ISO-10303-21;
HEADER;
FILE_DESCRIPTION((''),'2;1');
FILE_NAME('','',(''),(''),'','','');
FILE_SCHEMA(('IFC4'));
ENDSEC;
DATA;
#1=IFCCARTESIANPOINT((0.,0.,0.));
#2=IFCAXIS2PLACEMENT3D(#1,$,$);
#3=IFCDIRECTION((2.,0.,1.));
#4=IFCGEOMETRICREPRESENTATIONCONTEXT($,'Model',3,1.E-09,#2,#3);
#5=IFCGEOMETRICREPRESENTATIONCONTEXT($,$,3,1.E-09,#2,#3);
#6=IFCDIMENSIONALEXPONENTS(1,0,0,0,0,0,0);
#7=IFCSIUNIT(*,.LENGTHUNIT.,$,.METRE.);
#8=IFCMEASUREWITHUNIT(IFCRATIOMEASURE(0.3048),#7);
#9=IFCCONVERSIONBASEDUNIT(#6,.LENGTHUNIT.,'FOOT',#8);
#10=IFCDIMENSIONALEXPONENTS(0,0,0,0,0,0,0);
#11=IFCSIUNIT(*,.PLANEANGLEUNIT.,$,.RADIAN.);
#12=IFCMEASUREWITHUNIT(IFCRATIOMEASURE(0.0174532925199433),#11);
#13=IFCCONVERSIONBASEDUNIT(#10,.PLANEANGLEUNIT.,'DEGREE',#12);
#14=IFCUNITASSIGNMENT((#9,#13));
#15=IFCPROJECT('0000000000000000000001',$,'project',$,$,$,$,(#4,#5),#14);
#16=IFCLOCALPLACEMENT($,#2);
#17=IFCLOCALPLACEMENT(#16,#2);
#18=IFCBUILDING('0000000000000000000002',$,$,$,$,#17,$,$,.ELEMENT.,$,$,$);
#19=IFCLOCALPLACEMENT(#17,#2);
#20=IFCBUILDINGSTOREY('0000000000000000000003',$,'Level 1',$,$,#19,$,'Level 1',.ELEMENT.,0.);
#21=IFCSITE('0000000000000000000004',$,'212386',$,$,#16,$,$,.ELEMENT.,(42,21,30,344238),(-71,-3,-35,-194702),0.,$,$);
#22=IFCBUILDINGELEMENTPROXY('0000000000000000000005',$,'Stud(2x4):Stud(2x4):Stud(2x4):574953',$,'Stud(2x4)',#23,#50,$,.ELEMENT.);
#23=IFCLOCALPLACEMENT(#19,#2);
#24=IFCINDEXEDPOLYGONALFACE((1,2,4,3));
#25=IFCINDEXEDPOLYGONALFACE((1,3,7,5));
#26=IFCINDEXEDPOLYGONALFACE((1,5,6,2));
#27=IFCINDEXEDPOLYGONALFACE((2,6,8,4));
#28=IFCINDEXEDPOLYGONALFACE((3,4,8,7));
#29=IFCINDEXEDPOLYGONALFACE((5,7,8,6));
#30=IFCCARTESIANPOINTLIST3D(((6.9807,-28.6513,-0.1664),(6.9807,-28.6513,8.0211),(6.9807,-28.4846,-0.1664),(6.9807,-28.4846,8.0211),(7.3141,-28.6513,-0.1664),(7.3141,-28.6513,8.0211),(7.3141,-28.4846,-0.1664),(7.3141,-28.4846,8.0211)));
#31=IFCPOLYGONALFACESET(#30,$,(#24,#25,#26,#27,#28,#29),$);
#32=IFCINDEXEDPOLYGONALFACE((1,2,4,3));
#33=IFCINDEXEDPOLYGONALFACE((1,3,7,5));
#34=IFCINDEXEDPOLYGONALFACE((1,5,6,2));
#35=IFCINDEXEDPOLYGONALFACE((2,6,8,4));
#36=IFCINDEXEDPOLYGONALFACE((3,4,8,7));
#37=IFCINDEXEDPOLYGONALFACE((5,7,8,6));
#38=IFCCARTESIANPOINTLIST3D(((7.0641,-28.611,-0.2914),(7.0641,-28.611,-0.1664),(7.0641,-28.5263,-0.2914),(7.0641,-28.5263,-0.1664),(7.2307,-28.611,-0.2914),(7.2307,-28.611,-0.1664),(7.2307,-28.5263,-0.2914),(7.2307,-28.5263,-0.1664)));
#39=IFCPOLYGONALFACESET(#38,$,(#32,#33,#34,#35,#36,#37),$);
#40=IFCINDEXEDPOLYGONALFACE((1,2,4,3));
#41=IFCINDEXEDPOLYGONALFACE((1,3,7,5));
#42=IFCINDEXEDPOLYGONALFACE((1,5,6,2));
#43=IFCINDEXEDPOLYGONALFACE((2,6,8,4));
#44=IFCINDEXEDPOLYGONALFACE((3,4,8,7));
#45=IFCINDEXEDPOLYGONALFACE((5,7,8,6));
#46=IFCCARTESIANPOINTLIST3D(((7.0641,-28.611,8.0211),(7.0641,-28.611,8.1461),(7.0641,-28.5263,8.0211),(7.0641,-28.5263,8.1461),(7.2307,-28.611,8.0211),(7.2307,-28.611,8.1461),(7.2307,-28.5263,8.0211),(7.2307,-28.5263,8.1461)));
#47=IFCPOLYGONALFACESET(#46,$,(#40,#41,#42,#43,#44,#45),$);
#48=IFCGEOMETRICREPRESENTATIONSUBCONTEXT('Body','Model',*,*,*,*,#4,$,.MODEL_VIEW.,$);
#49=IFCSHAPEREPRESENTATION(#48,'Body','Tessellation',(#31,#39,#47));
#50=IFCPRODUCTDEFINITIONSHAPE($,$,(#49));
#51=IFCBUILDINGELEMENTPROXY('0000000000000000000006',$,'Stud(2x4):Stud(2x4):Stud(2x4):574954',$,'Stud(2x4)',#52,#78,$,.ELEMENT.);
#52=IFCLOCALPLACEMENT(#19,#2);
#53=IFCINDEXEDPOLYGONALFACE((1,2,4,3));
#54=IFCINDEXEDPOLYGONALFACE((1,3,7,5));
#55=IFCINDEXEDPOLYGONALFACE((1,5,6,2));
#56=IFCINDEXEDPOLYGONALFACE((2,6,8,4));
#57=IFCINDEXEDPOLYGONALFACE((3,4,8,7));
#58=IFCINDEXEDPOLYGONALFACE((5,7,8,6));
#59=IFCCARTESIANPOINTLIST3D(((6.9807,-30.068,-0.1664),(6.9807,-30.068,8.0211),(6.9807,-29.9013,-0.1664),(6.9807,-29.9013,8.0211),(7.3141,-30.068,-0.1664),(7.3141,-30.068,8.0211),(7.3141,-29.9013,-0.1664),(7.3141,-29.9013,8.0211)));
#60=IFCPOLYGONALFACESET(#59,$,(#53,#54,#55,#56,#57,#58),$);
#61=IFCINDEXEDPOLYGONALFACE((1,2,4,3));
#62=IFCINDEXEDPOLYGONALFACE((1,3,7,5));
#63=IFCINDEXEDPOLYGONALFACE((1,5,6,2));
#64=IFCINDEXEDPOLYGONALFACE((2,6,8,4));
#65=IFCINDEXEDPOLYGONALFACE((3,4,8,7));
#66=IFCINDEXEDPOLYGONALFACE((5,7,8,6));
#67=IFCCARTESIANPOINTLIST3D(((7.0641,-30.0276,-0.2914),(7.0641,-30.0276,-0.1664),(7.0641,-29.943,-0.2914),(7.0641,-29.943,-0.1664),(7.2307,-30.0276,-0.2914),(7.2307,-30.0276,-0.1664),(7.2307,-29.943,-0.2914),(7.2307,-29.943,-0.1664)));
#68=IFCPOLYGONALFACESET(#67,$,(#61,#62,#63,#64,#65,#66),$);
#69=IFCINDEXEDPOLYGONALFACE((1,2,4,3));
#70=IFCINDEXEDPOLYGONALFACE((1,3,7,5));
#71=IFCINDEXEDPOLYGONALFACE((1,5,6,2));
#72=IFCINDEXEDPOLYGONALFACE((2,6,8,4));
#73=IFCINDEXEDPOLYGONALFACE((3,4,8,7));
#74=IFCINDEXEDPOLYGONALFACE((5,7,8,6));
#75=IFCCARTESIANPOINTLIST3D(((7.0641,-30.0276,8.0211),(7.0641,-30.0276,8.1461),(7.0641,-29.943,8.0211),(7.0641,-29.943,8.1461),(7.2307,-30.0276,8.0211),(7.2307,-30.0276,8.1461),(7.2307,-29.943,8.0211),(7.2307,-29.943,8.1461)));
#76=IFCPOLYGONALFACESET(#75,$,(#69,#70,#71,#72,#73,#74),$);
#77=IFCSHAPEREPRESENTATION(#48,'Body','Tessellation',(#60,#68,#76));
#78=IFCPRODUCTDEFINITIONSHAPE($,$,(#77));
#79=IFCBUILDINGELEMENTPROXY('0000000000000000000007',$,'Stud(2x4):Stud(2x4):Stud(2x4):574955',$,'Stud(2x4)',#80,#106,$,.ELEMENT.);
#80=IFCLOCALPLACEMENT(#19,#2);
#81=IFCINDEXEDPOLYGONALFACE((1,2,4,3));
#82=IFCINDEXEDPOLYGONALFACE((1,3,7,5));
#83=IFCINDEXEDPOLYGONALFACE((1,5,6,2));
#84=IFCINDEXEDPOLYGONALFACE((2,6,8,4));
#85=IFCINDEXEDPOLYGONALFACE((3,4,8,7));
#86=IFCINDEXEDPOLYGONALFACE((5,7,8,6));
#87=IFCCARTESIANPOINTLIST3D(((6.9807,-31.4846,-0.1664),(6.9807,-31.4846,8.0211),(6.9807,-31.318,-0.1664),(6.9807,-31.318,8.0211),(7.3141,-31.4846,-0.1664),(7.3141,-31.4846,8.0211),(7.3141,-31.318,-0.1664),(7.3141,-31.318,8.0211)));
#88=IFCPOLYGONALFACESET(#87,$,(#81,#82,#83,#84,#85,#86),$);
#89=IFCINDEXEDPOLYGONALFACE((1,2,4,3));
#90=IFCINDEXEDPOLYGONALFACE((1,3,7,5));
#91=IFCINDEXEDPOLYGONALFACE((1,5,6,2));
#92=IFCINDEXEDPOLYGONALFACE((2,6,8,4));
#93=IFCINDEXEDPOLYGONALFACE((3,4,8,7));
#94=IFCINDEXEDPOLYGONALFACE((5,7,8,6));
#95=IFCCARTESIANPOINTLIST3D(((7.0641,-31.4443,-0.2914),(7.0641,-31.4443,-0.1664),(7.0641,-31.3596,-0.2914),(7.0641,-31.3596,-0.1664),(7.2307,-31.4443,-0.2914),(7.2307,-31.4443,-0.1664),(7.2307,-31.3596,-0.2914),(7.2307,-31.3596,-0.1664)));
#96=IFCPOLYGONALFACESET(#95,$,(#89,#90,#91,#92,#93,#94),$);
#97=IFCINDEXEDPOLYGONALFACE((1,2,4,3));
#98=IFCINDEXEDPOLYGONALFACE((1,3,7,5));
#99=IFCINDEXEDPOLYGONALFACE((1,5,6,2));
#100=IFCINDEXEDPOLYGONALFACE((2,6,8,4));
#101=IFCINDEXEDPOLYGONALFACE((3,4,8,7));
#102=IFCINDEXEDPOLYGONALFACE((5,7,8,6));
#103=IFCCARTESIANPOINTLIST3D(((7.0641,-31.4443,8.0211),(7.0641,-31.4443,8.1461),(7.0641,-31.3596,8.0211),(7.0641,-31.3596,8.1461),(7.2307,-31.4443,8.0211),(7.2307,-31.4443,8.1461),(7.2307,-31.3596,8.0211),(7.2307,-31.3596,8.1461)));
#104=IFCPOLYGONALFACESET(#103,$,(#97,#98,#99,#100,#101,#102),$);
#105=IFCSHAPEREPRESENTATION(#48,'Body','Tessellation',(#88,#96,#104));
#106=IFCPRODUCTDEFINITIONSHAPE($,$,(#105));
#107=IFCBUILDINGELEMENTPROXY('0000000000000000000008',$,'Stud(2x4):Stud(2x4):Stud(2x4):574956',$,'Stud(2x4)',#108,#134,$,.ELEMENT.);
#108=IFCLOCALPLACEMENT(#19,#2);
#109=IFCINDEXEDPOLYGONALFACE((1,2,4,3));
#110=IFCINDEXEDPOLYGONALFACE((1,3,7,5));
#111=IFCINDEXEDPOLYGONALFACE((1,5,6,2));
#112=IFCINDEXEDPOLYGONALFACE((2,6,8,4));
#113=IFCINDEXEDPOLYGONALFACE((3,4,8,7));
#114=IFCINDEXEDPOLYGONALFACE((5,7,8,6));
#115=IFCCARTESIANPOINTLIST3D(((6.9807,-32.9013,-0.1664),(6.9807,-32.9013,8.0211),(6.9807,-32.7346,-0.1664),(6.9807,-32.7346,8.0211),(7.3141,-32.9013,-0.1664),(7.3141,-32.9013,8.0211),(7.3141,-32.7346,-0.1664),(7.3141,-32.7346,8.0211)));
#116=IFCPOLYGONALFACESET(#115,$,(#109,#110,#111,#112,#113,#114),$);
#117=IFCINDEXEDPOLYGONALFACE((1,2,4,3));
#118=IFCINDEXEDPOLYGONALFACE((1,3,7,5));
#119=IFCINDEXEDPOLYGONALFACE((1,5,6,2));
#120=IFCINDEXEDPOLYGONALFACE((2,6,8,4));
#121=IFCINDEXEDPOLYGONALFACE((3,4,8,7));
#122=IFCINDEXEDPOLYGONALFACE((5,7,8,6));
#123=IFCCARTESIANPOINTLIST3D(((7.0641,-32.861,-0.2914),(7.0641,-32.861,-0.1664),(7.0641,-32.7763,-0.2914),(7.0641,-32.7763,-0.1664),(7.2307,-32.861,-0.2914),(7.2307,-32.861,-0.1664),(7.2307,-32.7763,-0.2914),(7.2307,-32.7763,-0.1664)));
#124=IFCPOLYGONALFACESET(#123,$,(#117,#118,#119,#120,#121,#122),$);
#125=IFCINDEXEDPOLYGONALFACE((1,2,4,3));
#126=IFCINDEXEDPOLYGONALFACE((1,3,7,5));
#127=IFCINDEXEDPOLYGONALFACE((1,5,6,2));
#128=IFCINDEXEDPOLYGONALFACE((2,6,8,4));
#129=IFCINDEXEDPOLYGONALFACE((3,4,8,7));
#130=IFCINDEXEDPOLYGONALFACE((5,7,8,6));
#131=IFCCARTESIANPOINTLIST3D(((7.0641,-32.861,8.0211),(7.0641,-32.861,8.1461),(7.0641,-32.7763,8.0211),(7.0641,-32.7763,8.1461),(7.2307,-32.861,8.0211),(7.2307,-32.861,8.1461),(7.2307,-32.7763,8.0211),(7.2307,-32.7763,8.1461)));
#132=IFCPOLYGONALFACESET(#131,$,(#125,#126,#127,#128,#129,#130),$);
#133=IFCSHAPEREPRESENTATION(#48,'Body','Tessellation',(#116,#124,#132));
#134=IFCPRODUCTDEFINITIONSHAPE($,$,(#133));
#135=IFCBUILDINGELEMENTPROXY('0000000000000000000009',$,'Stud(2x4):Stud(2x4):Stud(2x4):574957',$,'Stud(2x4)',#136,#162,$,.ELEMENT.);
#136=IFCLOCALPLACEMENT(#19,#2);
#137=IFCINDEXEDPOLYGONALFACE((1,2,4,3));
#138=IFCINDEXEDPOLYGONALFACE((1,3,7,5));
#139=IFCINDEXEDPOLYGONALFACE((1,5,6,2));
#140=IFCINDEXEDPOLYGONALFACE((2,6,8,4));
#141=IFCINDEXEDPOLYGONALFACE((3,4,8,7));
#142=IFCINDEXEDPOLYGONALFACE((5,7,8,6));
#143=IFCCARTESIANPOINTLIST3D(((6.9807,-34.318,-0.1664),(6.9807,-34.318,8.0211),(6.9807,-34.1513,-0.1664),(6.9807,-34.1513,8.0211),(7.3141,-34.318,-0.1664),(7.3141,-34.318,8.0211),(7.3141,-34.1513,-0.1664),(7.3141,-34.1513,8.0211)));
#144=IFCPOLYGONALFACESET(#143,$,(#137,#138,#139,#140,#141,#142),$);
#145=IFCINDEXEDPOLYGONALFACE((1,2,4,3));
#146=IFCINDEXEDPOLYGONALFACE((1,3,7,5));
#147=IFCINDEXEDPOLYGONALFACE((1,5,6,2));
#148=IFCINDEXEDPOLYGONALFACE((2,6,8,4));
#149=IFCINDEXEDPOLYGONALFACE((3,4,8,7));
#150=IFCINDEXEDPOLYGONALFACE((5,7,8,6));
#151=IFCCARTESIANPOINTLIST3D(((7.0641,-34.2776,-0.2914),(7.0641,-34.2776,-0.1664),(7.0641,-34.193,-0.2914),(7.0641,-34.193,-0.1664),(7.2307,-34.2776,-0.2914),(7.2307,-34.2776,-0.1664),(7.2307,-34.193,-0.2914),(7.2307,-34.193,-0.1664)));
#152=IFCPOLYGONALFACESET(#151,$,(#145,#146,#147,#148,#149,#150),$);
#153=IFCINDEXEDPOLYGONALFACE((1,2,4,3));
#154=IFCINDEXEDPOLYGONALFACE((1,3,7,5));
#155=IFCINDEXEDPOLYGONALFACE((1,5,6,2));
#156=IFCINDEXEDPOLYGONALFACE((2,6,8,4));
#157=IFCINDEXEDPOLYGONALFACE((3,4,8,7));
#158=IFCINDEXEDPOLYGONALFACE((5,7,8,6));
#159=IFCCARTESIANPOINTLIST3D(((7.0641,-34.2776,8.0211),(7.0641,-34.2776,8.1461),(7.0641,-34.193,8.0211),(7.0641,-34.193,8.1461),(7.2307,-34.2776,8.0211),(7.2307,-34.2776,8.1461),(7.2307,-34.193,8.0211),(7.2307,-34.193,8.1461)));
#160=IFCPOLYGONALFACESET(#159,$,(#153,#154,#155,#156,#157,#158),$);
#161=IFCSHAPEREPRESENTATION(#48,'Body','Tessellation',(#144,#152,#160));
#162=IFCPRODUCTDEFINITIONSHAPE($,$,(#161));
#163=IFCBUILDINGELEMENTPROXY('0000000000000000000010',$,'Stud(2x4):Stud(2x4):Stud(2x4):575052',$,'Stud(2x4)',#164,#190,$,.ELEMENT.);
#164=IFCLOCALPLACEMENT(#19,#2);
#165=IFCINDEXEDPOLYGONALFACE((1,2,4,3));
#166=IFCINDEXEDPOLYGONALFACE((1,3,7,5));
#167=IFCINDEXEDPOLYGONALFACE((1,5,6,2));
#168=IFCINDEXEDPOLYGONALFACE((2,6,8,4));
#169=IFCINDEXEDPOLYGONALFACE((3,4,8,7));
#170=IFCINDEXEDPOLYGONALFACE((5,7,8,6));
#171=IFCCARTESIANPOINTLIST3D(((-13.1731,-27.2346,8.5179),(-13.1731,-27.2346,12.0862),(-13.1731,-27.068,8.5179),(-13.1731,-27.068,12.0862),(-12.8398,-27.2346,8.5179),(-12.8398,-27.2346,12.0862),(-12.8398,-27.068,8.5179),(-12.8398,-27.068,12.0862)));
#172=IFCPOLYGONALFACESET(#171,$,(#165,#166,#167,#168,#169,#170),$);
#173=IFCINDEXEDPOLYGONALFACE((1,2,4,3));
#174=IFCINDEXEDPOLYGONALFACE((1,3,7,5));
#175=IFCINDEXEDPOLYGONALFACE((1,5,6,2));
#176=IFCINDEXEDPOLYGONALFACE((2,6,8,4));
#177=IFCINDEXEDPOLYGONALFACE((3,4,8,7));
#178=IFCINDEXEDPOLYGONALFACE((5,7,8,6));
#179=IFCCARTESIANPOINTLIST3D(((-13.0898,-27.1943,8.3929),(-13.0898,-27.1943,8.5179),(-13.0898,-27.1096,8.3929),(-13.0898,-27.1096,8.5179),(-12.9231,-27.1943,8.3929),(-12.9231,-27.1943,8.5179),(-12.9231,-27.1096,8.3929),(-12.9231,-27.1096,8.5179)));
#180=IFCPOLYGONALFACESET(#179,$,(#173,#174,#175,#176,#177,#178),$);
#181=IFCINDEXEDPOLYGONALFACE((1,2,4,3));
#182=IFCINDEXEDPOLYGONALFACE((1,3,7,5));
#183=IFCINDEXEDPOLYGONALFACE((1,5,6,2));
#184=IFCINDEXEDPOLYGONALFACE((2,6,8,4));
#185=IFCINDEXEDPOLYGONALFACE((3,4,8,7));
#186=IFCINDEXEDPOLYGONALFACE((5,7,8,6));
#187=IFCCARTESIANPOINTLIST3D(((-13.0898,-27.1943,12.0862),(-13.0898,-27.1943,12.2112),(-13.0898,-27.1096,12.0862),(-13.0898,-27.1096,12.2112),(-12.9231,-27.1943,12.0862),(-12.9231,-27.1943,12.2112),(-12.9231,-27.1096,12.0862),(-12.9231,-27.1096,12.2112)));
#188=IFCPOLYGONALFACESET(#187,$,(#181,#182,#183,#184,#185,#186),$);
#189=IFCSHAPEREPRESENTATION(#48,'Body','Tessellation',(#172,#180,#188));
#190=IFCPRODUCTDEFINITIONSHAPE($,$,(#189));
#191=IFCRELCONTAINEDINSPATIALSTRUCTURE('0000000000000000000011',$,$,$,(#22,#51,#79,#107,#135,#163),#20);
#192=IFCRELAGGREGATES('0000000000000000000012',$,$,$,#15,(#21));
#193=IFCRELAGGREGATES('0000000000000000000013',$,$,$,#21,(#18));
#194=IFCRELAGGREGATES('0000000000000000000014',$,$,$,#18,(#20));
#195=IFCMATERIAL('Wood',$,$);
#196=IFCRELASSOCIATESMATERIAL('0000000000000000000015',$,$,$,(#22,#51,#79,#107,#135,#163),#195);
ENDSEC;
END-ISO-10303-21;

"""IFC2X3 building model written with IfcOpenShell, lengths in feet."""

from ifc_helpers import new_model, entity, si_unit, converted_unit, direction, frame, frame_2d, origin, place, context, subcontext, project, spatial, rectangle, extrude, source, transform, mapped, material, element, save


model = new_model("IFC2X3")

# Units and contexts
model_context = context("Model", 3, precision=1e-09, world=origin(), true_north=direction((2.0, 0.0, 1.0)))
context_of_model = context(None, 3, precision=1e-09, world=origin(), true_north=direction((2.0, 0.0, 1.0)))
body_context = subcontext(model_context, "Body", "Model", "MODEL_VIEW")
ifc_project = project(units=[converted_unit("LENGTHUNIT", "FOOT", entity("IfcRatioMeasure", 0.3048), si_unit("LENGTHUNIT", "METRE"), dimensions=[1, 0, 0, 0, 0, 0, 0]), converted_unit("PLANEANGLEUNIT", "DEGREE", entity("IfcRatioMeasure", 0.0174532925199433), si_unit("PLANEANGLEUNIT", "RADIAN"), dimensions=[0, 0, 0, 0, 0, 0, 0])], contexts=[model_context, context_of_model])

# Site, building, storey
site_placement = place(None, origin())
site = spatial("IfcSite", under=ifc_project, at=site_placement, Name="212386", CompositionType="ELEMENT", RefLatitude=(42, 21, 30, 344238), RefLongitude=(-71, -3, -35, -194702), RefElevation=0.0)
building_placement = place(site_placement, origin())
building = spatial("IfcBuilding", under=site, at=building_placement, CompositionType="ELEMENT")
storey_placement = place(building_placement, origin())
storey = spatial("IfcBuildingStorey", under=building, at=storey_placement, Name="Level 1", LongName="Level 1", CompositionType="ELEMENT", Elevation=0.0)

# Building element proxies
ifc_material = material(Name="Wood")
shared_shape_1 = source(origin(), body_context, "Body", "SweptSolid", [
    extrude(rectangle(XDim=0.3333, YDim=0.1667, at=frame_2d((0.0, 0.0), x_axis=(1.0, 0.0))), frame((7.1474, -28.568, -0.1664), z_axis=(0.0, 0.0, 1.0), x_axis=(-1.0, 0.0, 0.0)), (0.0, 0.0, 1.0), 8.1875),
    extrude(rectangle(XDim=0.1667, YDim=0.0847, at=frame_2d((0.0, 0.0), x_axis=(1.0, 0.0))), frame((7.1474, -28.5686, -0.2914), z_axis=(0.0, 0.0, 1.0), x_axis=(-1.0, 0.0, 0.0)), (0.0, 0.0, 1.0), 0.125),
    extrude(rectangle(XDim=0.0847, YDim=0.1667, at=frame_2d((0.0, 0.0), x_axis=(1.0, 0.0))), frame((7.1474, -28.5686, 8.0211), z_axis=(0.0, 0.0, 1.0), x_axis=(0.0, -1.0, 0.0)), (0.0, 0.0, 1.0), 0.125),
])
proxy_1_placement = place(storey_placement, origin())
element("IfcBuildingElementProxy", 1, at=proxy_1_placement, inside=storey, material=ifc_material, Name="Stud(2x4):Stud(2x4):Stud(2x4):574953", ObjectType="Stud(2x4)", CompositionType="ELEMENT", context=body_context, shape_type="MappedRepresentation", body=[
    mapped(shared_shape_1, transform((0.0, 0.0, 0.0), scale=1.0)),
])
shared_shape_2 = source(origin(), body_context, "Body", "SweptSolid", [
    extrude(rectangle(XDim=0.3333, YDim=0.1667, at=frame_2d((0.0, 0.0), x_axis=(1.0, 0.0))), frame((7.1474, -29.9846, -0.1664), z_axis=(0.0, 0.0, 1.0), x_axis=(-1.0, 0.0, 0.0)), (0.0, 0.0, 1.0), 8.1875),
    extrude(rectangle(XDim=0.1667, YDim=0.0847, at=frame_2d((0.0, 0.0), x_axis=(1.0, 0.0))), frame((7.1474, -29.9853, -0.2914), z_axis=(0.0, 0.0, 1.0), x_axis=(-1.0, 0.0, 0.0)), (0.0, 0.0, 1.0), 0.125),
    extrude(rectangle(XDim=0.0847, YDim=0.1667, at=frame_2d((0.0, 0.0), x_axis=(1.0, 0.0))), frame((7.1474, -29.9853, 8.0211), z_axis=(0.0, 0.0, 1.0), x_axis=(0.0, -1.0, 0.0)), (0.0, 0.0, 1.0), 0.125),
])
proxy_2_placement = place(storey_placement, origin())
element("IfcBuildingElementProxy", 2, at=proxy_2_placement, inside=storey, material=ifc_material, Name="Stud(2x4):Stud(2x4):Stud(2x4):574954", ObjectType="Stud(2x4)", CompositionType="ELEMENT", context=body_context, shape_type="MappedRepresentation", body=[
    mapped(shared_shape_2, transform((0.0, 0.0, 0.0), scale=1.0)),
])
shared_shape_3 = source(origin(), body_context, "Body", "SweptSolid", [
    extrude(rectangle(XDim=0.3333, YDim=0.1667, at=frame_2d((0.0, 0.0), x_axis=(1.0, 0.0))), frame((7.1474, -31.4013, -0.1664), z_axis=(0.0, 0.0, 1.0), x_axis=(-1.0, 0.0, 0.0)), (0.0, 0.0, 1.0), 8.1875),
    extrude(rectangle(XDim=0.1667, YDim=0.0847, at=frame_2d((0.0, 0.0), x_axis=(1.0, 0.0))), frame((7.1474, -31.402, -0.2914), z_axis=(0.0, 0.0, 1.0), x_axis=(-1.0, 0.0, 0.0)), (0.0, 0.0, 1.0), 0.125),
    extrude(rectangle(XDim=0.0847, YDim=0.1667, at=frame_2d((0.0, 0.0), x_axis=(1.0, 0.0))), frame((7.1474, -31.402, 8.0211), z_axis=(0.0, 0.0, 1.0), x_axis=(0.0, -1.0, 0.0)), (0.0, 0.0, 1.0), 0.125),
])
proxy_3_placement = place(storey_placement, origin())
element("IfcBuildingElementProxy", 3, at=proxy_3_placement, inside=storey, material=ifc_material, Name="Stud(2x4):Stud(2x4):Stud(2x4):574955", ObjectType="Stud(2x4)", CompositionType="ELEMENT", context=body_context, shape_type="MappedRepresentation", body=[
    mapped(shared_shape_3, transform((0.0, 0.0, 0.0), scale=1.0)),
])
shared_shape_4 = source(origin(), body_context, "Body", "SweptSolid", [
    extrude(rectangle(XDim=0.3333, YDim=0.1667, at=frame_2d((0.0, 0.0), x_axis=(1.0, 0.0))), frame((7.1474, -32.818, -0.1664), z_axis=(0.0, 0.0, 1.0), x_axis=(-1.0, 0.0, 0.0)), (0.0, 0.0, 1.0), 8.1875),
    extrude(rectangle(XDim=0.1667, YDim=0.0847, at=frame_2d((0.0, 0.0), x_axis=(1.0, 0.0))), frame((7.1474, -32.8186, -0.2914), z_axis=(0.0, 0.0, 1.0), x_axis=(-1.0, 0.0, 0.0)), (0.0, 0.0, 1.0), 0.125),
    extrude(rectangle(XDim=0.0847, YDim=0.1667, at=frame_2d((0.0, 0.0), x_axis=(1.0, 0.0))), frame((7.1474, -32.8186, 8.0211), z_axis=(0.0, 0.0, 1.0), x_axis=(0.0, -1.0, 0.0)), (0.0, 0.0, 1.0), 0.125),
])
proxy_4_placement = place(storey_placement, origin())
element("IfcBuildingElementProxy", 4, at=proxy_4_placement, inside=storey, material=ifc_material, Name="Stud(2x4):Stud(2x4):Stud(2x4):574956", ObjectType="Stud(2x4)", CompositionType="ELEMENT", context=body_context, shape_type="MappedRepresentation", body=[
    mapped(shared_shape_4, transform((0.0, 0.0, 0.0), scale=1.0)),
])
shared_shape_5 = source(origin(), body_context, "Body", "SweptSolid", [
    extrude(rectangle(XDim=0.3333, YDim=0.1667, at=frame_2d((0.0, 0.0), x_axis=(1.0, 0.0))), frame((7.1474, -34.2346, -0.1664), z_axis=(0.0, 0.0, 1.0), x_axis=(-1.0, 0.0, 0.0)), (0.0, 0.0, 1.0), 8.1875),
    extrude(rectangle(XDim=0.1667, YDim=0.0847, at=frame_2d((0.0, 0.0), x_axis=(1.0, 0.0))), frame((7.1474, -34.2353, -0.2914), z_axis=(0.0, 0.0, 1.0), x_axis=(-1.0, 0.0, 0.0)), (0.0, 0.0, 1.0), 0.125),
    extrude(rectangle(XDim=0.0847, YDim=0.1667, at=frame_2d((0.0, 0.0), x_axis=(1.0, 0.0))), frame((7.1474, -34.2353, 8.0211), z_axis=(0.0, 0.0, 1.0), x_axis=(0.0, -1.0, 0.0)), (0.0, 0.0, 1.0), 0.125),
])
proxy_5_placement = place(storey_placement, origin())
element("IfcBuildingElementProxy", 5, at=proxy_5_placement, inside=storey, material=ifc_material, Name="Stud(2x4):Stud(2x4):Stud(2x4):574957", ObjectType="Stud(2x4)", CompositionType="ELEMENT", context=body_context, shape_type="MappedRepresentation", body=[
    mapped(shared_shape_5, transform((0.0, 0.0, 0.0), scale=1.0)),
])
shared_shape_6 = source(origin(), body_context, "Body", "SweptSolid", [
    extrude(rectangle(XDim=0.3333, YDim=0.1667, at=frame_2d((0.0, 0.0), x_axis=(1.0, 0.0))), frame((-13.0064, -27.1513, 8.5179), z_axis=(0.0, 0.0, 1.0), x_axis=(-1.0, 0.0, 0.0)), (0.0, 0.0, 1.0), 3.5684),
    extrude(rectangle(XDim=0.1667, YDim=0.0847, at=frame_2d((0.0, 0.0), x_axis=(1.0, 0.0))), frame((-13.0064, -27.152, 8.3929), z_axis=(0.0, 0.0, 1.0), x_axis=(-1.0, 0.0, 0.0)), (0.0, 0.0, 1.0), 0.125),
    extrude(rectangle(XDim=0.0847, YDim=0.1667, at=frame_2d((0.0, 0.0), x_axis=(1.0, 0.0))), frame((-13.0064, -27.152, 12.0862), z_axis=(0.0, 0.0, 1.0), x_axis=(0.0, -1.0, 0.0)), (0.0, 0.0, 1.0), 0.125),
])
proxy_6_placement = place(storey_placement, origin())
element("IfcBuildingElementProxy", 6, at=proxy_6_placement, inside=storey, material=ifc_material, Name="Stud(2x4):Stud(2x4):Stud(2x4):575052", ObjectType="Stud(2x4)", CompositionType="ELEMENT", context=body_context, shape_type="MappedRepresentation", body=[
    mapped(shared_shape_6, transform((0.0, 0.0, 0.0), scale=1.0)),
])

save(model, "model.ifc")
